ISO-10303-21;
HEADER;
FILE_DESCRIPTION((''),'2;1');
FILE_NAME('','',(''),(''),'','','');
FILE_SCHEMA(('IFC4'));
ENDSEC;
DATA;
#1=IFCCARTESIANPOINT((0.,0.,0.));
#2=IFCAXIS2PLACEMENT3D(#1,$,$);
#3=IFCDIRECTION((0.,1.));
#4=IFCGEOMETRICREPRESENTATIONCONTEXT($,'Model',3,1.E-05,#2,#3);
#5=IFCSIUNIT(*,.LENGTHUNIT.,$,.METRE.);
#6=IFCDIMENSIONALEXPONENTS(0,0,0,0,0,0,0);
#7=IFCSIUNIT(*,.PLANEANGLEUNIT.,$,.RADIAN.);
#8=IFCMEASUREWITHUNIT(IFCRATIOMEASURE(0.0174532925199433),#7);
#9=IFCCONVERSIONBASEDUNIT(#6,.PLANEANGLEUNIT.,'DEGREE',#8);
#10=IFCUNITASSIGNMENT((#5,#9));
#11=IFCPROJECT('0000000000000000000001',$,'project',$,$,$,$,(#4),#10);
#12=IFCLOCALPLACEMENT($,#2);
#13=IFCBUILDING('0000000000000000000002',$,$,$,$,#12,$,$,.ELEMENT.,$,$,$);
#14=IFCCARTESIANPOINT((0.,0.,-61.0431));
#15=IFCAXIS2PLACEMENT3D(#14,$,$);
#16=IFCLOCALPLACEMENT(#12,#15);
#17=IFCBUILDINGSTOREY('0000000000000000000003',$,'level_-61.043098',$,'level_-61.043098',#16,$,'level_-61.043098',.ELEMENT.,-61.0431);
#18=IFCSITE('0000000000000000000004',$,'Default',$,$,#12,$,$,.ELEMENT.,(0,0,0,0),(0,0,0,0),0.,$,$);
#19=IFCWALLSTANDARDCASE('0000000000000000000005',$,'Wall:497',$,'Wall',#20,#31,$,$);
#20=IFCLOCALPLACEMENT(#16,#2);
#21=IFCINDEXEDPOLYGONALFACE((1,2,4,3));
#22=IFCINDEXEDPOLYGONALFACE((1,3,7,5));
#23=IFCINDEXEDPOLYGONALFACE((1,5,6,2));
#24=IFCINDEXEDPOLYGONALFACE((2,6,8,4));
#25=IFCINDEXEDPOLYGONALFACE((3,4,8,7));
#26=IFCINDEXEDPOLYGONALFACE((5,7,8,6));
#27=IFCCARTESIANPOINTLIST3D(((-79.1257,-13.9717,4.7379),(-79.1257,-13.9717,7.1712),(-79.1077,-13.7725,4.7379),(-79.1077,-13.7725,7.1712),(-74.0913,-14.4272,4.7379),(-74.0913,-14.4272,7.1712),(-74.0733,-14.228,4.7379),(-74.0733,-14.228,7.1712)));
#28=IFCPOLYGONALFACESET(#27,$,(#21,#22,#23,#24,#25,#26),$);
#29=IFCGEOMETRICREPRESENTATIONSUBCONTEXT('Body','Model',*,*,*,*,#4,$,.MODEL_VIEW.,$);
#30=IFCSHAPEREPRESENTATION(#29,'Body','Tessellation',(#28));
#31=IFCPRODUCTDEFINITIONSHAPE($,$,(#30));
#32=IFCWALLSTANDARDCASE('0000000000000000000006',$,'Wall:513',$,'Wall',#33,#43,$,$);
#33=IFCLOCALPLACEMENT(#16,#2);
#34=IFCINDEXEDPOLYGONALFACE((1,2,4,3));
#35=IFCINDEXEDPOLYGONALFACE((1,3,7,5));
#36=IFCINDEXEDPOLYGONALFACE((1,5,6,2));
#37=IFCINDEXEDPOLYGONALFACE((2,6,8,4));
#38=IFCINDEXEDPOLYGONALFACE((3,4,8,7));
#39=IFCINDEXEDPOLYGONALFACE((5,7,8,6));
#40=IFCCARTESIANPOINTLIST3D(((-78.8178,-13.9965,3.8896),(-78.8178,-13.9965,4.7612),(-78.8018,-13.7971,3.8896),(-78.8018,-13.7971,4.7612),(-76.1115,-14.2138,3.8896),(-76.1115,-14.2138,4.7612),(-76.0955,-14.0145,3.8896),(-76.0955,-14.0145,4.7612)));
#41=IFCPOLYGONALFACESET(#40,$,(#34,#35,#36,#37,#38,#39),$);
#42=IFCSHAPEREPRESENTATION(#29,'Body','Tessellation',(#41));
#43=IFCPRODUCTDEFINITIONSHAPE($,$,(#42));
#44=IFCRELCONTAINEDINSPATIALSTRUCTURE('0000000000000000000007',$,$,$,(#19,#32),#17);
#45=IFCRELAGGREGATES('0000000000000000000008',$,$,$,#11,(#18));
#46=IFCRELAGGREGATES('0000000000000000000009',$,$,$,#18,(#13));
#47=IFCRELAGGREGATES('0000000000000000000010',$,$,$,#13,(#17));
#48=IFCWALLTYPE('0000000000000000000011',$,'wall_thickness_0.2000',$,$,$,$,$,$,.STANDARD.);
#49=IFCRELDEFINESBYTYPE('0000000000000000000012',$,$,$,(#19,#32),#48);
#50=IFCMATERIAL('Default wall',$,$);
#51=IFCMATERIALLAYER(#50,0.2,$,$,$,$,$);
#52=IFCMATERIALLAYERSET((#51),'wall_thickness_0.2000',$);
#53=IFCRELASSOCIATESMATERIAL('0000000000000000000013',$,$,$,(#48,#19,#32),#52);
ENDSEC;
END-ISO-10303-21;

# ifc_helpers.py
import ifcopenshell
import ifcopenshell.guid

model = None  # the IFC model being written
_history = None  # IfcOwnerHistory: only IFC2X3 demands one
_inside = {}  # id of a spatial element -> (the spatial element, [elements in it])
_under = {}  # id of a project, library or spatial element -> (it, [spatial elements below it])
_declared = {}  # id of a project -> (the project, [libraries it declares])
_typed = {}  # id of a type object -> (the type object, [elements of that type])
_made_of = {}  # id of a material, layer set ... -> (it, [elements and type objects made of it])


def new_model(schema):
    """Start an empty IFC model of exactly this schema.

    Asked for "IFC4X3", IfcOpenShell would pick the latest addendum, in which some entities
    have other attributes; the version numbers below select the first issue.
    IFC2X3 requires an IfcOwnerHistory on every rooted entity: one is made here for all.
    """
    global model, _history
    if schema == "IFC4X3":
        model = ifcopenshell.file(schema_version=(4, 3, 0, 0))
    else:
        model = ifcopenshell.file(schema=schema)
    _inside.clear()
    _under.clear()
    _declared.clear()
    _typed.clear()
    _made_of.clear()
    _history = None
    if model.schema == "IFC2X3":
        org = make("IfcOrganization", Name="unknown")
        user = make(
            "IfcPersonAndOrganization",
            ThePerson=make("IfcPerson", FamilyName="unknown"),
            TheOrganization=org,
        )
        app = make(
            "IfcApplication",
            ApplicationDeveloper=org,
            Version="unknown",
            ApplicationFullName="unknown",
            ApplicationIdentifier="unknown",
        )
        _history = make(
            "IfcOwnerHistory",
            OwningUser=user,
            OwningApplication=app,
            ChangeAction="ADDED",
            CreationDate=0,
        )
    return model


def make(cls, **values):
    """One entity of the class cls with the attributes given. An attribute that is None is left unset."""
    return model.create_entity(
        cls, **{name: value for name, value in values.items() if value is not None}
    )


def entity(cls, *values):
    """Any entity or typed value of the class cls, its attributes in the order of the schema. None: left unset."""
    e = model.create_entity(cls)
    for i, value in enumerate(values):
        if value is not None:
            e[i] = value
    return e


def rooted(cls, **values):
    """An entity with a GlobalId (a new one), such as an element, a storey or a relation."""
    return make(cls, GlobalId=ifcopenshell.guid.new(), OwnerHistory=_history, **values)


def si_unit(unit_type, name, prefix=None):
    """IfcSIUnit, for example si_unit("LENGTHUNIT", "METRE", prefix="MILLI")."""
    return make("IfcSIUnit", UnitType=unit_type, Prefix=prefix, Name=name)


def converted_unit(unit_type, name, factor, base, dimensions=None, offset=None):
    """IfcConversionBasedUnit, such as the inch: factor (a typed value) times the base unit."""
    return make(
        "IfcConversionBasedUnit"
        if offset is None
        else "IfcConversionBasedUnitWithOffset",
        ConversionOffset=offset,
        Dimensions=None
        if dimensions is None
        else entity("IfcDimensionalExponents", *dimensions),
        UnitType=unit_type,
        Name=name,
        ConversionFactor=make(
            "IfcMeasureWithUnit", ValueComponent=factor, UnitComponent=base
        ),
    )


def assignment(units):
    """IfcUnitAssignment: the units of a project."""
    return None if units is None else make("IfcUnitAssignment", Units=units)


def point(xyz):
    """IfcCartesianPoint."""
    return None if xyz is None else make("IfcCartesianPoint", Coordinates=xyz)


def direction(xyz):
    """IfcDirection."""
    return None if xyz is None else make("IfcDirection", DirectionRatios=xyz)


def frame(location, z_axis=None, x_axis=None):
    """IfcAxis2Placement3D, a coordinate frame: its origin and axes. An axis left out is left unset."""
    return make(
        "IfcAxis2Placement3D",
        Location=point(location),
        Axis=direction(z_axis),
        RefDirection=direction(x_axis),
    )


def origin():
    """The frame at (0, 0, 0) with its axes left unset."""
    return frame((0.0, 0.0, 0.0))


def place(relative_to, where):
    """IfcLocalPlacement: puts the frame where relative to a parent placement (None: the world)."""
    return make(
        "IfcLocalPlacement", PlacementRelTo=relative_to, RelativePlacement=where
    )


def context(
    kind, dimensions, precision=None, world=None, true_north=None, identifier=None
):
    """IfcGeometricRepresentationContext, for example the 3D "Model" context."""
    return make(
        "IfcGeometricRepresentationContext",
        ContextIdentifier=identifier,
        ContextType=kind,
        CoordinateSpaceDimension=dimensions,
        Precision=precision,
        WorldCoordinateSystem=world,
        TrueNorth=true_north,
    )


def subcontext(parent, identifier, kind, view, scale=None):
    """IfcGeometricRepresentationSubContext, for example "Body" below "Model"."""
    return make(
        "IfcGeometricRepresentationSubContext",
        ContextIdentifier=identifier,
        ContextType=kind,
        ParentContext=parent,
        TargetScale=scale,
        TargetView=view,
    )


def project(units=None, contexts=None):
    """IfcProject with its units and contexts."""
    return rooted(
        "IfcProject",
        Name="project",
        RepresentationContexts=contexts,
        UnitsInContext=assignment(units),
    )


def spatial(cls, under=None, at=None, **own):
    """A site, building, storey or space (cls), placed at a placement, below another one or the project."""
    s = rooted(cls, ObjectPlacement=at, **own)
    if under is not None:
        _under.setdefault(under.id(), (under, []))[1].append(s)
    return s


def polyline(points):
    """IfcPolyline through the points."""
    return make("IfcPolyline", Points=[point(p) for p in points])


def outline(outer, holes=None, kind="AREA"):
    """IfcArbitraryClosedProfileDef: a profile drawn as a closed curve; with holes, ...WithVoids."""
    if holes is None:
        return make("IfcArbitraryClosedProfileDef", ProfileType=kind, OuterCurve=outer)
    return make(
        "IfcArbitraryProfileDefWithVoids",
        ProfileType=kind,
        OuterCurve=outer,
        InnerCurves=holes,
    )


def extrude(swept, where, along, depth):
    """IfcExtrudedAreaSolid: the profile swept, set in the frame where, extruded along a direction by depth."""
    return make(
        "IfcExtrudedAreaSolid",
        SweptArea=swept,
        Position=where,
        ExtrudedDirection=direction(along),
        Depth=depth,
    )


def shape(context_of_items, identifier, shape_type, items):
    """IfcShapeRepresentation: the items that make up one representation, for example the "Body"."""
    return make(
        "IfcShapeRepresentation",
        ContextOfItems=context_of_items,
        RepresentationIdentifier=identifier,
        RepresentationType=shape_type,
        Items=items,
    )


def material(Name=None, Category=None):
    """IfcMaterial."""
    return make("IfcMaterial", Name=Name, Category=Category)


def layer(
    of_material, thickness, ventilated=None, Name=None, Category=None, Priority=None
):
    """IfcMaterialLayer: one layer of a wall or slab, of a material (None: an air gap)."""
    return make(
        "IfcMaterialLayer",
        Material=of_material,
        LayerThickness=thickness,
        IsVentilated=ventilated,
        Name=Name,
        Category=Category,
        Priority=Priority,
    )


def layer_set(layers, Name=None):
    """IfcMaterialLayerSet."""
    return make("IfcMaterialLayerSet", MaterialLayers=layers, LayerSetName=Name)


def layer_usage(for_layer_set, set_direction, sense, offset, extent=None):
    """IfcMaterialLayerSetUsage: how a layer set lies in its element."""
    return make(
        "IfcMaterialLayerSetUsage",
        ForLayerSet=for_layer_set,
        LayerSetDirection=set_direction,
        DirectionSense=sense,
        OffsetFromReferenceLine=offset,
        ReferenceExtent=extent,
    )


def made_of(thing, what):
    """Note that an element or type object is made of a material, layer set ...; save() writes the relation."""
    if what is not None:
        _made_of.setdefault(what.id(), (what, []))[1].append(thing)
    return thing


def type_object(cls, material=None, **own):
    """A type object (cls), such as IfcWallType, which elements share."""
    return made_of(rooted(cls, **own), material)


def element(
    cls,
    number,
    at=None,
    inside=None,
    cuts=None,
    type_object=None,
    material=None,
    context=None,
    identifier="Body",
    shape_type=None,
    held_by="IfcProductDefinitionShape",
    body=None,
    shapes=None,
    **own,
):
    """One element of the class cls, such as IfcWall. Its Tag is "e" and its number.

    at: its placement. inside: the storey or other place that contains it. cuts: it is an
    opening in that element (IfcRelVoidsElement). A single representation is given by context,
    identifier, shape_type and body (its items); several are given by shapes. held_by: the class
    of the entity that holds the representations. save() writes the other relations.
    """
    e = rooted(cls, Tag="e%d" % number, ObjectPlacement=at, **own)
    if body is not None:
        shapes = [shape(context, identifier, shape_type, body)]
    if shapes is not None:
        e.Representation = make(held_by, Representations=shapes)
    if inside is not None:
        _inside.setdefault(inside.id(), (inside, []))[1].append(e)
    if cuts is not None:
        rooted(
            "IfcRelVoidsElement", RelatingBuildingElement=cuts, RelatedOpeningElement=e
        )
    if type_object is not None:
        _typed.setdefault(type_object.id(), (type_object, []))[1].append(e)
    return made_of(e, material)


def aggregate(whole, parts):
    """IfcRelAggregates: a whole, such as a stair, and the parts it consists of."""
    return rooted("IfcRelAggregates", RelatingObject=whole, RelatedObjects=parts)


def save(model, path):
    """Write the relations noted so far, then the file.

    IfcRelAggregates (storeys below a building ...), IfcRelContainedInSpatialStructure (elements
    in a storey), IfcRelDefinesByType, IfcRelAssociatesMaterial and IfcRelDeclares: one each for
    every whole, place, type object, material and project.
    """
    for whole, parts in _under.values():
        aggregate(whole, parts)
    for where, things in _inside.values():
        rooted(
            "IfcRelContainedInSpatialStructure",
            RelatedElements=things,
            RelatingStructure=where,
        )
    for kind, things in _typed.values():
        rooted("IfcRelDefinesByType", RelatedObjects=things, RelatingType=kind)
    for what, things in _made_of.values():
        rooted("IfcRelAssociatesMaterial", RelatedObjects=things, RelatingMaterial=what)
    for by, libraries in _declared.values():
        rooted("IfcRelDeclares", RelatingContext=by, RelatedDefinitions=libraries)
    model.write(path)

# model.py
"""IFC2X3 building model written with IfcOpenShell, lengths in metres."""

from ifc_helpers import new_model, entity, si_unit, converted_unit, direction, frame, origin, place, context, subcontext, project, spatial, polyline, outline, extrude, material, layer, layer_set, layer_usage, type_object, element, save


model = new_model("IFC2X3")

# Units and contexts
model_context = context("Model", 3, precision=1e-05, world=origin(), true_north=direction((0.0, 1.0)))
body_context = subcontext(model_context, "Body", "Model", "MODEL_VIEW")
ifc_project = project(units=[si_unit("LENGTHUNIT", "METRE"), converted_unit("PLANEANGLEUNIT", "DEGREE", entity("IfcRatioMeasure", 0.0174532925199433), si_unit("PLANEANGLEUNIT", "RADIAN"), dimensions=[0, 0, 0, 0, 0, 0, 0])], contexts=[model_context])

# Site, building, storey
placement_1 = place(None, origin())
site = spatial("IfcSite", under=ifc_project, at=placement_1, Name="Default", CompositionType="ELEMENT", RefLatitude=(0, 0, 0, 0), RefLongitude=(0, 0, 0, 0), RefElevation=0.0)
building = spatial("IfcBuilding", under=site, at=placement_1, CompositionType="ELEMENT")
storey_placement = place(placement_1, frame((0.0, 0.0, -61.0431)))
storey = spatial("IfcBuildingStorey", under=building, at=storey_placement, Name="level_-61.043098", ObjectType="level_-61.043098", LongName="level_-61.043098", CompositionType="ELEMENT", Elevation=-61.0431)

# Walls
ifc_material = material(Name="Default wall")
ifc_layer = layer(ifc_material, 0.2)
ifc_layer_set = layer_set([ifc_layer], Name="wall_thickness_0.2000")
ifc_layer_usage = layer_usage(ifc_layer_set, "AXIS2", "POSITIVE", -0.1)
wall_type = type_object("IfcWallType", Name="wall_thickness_0.2000", PredefinedType="STANDARD", material=ifc_layer_set)
placement_2 = place(placement_1, frame((0.0, 0.0, -56.3052)))
wall_1_placement = place(placement_2, frame((-79.1167, -13.8721, 0.0), z_axis=(0.0, 0.0, 1.0), x_axis=(0.995931, -0.090121, 0.0)))
element("IfcWallStandardCase", 1, at=wall_1_placement, inside=storey, type_object=wall_type, material=ifc_layer_usage, Name="Wall:497", ObjectType="Wall", context=body_context, shape_type="SweptSolid", body=[
    extrude(outline(polyline([(5.055, -0.1), (5.055, 0.1), (0.0, 0.1), (0.0, -0.1), (5.055, -0.1)])), origin(), (0.0, 0.0, 1.0), 2.4333),
])
placement_3 = place(placement_1, frame((0.0, 0.0, -57.1535)))
wall_2_placement = place(placement_3, frame((-78.8098, -13.8968, 0.0), z_axis=(0.0, 0.0, 1.0), x_axis=(0.996792, -0.08004, 0.0)))
element("IfcWallStandardCase", 2, at=wall_2_placement, inside=storey, type_object=wall_type, material=ifc_layer_usage, Name="Wall:513", ObjectType="Wall", context=body_context, shape_type="SweptSolid", body=[
    extrude(outline(polyline([(2.715, -0.1), (2.715, 0.1), (0.0, 0.1), (0.0, -0.1), (2.715, -0.1)])), origin(), (0.0, 0.0, 1.0), 0.8716),
])

save(model, "model.ifc")
